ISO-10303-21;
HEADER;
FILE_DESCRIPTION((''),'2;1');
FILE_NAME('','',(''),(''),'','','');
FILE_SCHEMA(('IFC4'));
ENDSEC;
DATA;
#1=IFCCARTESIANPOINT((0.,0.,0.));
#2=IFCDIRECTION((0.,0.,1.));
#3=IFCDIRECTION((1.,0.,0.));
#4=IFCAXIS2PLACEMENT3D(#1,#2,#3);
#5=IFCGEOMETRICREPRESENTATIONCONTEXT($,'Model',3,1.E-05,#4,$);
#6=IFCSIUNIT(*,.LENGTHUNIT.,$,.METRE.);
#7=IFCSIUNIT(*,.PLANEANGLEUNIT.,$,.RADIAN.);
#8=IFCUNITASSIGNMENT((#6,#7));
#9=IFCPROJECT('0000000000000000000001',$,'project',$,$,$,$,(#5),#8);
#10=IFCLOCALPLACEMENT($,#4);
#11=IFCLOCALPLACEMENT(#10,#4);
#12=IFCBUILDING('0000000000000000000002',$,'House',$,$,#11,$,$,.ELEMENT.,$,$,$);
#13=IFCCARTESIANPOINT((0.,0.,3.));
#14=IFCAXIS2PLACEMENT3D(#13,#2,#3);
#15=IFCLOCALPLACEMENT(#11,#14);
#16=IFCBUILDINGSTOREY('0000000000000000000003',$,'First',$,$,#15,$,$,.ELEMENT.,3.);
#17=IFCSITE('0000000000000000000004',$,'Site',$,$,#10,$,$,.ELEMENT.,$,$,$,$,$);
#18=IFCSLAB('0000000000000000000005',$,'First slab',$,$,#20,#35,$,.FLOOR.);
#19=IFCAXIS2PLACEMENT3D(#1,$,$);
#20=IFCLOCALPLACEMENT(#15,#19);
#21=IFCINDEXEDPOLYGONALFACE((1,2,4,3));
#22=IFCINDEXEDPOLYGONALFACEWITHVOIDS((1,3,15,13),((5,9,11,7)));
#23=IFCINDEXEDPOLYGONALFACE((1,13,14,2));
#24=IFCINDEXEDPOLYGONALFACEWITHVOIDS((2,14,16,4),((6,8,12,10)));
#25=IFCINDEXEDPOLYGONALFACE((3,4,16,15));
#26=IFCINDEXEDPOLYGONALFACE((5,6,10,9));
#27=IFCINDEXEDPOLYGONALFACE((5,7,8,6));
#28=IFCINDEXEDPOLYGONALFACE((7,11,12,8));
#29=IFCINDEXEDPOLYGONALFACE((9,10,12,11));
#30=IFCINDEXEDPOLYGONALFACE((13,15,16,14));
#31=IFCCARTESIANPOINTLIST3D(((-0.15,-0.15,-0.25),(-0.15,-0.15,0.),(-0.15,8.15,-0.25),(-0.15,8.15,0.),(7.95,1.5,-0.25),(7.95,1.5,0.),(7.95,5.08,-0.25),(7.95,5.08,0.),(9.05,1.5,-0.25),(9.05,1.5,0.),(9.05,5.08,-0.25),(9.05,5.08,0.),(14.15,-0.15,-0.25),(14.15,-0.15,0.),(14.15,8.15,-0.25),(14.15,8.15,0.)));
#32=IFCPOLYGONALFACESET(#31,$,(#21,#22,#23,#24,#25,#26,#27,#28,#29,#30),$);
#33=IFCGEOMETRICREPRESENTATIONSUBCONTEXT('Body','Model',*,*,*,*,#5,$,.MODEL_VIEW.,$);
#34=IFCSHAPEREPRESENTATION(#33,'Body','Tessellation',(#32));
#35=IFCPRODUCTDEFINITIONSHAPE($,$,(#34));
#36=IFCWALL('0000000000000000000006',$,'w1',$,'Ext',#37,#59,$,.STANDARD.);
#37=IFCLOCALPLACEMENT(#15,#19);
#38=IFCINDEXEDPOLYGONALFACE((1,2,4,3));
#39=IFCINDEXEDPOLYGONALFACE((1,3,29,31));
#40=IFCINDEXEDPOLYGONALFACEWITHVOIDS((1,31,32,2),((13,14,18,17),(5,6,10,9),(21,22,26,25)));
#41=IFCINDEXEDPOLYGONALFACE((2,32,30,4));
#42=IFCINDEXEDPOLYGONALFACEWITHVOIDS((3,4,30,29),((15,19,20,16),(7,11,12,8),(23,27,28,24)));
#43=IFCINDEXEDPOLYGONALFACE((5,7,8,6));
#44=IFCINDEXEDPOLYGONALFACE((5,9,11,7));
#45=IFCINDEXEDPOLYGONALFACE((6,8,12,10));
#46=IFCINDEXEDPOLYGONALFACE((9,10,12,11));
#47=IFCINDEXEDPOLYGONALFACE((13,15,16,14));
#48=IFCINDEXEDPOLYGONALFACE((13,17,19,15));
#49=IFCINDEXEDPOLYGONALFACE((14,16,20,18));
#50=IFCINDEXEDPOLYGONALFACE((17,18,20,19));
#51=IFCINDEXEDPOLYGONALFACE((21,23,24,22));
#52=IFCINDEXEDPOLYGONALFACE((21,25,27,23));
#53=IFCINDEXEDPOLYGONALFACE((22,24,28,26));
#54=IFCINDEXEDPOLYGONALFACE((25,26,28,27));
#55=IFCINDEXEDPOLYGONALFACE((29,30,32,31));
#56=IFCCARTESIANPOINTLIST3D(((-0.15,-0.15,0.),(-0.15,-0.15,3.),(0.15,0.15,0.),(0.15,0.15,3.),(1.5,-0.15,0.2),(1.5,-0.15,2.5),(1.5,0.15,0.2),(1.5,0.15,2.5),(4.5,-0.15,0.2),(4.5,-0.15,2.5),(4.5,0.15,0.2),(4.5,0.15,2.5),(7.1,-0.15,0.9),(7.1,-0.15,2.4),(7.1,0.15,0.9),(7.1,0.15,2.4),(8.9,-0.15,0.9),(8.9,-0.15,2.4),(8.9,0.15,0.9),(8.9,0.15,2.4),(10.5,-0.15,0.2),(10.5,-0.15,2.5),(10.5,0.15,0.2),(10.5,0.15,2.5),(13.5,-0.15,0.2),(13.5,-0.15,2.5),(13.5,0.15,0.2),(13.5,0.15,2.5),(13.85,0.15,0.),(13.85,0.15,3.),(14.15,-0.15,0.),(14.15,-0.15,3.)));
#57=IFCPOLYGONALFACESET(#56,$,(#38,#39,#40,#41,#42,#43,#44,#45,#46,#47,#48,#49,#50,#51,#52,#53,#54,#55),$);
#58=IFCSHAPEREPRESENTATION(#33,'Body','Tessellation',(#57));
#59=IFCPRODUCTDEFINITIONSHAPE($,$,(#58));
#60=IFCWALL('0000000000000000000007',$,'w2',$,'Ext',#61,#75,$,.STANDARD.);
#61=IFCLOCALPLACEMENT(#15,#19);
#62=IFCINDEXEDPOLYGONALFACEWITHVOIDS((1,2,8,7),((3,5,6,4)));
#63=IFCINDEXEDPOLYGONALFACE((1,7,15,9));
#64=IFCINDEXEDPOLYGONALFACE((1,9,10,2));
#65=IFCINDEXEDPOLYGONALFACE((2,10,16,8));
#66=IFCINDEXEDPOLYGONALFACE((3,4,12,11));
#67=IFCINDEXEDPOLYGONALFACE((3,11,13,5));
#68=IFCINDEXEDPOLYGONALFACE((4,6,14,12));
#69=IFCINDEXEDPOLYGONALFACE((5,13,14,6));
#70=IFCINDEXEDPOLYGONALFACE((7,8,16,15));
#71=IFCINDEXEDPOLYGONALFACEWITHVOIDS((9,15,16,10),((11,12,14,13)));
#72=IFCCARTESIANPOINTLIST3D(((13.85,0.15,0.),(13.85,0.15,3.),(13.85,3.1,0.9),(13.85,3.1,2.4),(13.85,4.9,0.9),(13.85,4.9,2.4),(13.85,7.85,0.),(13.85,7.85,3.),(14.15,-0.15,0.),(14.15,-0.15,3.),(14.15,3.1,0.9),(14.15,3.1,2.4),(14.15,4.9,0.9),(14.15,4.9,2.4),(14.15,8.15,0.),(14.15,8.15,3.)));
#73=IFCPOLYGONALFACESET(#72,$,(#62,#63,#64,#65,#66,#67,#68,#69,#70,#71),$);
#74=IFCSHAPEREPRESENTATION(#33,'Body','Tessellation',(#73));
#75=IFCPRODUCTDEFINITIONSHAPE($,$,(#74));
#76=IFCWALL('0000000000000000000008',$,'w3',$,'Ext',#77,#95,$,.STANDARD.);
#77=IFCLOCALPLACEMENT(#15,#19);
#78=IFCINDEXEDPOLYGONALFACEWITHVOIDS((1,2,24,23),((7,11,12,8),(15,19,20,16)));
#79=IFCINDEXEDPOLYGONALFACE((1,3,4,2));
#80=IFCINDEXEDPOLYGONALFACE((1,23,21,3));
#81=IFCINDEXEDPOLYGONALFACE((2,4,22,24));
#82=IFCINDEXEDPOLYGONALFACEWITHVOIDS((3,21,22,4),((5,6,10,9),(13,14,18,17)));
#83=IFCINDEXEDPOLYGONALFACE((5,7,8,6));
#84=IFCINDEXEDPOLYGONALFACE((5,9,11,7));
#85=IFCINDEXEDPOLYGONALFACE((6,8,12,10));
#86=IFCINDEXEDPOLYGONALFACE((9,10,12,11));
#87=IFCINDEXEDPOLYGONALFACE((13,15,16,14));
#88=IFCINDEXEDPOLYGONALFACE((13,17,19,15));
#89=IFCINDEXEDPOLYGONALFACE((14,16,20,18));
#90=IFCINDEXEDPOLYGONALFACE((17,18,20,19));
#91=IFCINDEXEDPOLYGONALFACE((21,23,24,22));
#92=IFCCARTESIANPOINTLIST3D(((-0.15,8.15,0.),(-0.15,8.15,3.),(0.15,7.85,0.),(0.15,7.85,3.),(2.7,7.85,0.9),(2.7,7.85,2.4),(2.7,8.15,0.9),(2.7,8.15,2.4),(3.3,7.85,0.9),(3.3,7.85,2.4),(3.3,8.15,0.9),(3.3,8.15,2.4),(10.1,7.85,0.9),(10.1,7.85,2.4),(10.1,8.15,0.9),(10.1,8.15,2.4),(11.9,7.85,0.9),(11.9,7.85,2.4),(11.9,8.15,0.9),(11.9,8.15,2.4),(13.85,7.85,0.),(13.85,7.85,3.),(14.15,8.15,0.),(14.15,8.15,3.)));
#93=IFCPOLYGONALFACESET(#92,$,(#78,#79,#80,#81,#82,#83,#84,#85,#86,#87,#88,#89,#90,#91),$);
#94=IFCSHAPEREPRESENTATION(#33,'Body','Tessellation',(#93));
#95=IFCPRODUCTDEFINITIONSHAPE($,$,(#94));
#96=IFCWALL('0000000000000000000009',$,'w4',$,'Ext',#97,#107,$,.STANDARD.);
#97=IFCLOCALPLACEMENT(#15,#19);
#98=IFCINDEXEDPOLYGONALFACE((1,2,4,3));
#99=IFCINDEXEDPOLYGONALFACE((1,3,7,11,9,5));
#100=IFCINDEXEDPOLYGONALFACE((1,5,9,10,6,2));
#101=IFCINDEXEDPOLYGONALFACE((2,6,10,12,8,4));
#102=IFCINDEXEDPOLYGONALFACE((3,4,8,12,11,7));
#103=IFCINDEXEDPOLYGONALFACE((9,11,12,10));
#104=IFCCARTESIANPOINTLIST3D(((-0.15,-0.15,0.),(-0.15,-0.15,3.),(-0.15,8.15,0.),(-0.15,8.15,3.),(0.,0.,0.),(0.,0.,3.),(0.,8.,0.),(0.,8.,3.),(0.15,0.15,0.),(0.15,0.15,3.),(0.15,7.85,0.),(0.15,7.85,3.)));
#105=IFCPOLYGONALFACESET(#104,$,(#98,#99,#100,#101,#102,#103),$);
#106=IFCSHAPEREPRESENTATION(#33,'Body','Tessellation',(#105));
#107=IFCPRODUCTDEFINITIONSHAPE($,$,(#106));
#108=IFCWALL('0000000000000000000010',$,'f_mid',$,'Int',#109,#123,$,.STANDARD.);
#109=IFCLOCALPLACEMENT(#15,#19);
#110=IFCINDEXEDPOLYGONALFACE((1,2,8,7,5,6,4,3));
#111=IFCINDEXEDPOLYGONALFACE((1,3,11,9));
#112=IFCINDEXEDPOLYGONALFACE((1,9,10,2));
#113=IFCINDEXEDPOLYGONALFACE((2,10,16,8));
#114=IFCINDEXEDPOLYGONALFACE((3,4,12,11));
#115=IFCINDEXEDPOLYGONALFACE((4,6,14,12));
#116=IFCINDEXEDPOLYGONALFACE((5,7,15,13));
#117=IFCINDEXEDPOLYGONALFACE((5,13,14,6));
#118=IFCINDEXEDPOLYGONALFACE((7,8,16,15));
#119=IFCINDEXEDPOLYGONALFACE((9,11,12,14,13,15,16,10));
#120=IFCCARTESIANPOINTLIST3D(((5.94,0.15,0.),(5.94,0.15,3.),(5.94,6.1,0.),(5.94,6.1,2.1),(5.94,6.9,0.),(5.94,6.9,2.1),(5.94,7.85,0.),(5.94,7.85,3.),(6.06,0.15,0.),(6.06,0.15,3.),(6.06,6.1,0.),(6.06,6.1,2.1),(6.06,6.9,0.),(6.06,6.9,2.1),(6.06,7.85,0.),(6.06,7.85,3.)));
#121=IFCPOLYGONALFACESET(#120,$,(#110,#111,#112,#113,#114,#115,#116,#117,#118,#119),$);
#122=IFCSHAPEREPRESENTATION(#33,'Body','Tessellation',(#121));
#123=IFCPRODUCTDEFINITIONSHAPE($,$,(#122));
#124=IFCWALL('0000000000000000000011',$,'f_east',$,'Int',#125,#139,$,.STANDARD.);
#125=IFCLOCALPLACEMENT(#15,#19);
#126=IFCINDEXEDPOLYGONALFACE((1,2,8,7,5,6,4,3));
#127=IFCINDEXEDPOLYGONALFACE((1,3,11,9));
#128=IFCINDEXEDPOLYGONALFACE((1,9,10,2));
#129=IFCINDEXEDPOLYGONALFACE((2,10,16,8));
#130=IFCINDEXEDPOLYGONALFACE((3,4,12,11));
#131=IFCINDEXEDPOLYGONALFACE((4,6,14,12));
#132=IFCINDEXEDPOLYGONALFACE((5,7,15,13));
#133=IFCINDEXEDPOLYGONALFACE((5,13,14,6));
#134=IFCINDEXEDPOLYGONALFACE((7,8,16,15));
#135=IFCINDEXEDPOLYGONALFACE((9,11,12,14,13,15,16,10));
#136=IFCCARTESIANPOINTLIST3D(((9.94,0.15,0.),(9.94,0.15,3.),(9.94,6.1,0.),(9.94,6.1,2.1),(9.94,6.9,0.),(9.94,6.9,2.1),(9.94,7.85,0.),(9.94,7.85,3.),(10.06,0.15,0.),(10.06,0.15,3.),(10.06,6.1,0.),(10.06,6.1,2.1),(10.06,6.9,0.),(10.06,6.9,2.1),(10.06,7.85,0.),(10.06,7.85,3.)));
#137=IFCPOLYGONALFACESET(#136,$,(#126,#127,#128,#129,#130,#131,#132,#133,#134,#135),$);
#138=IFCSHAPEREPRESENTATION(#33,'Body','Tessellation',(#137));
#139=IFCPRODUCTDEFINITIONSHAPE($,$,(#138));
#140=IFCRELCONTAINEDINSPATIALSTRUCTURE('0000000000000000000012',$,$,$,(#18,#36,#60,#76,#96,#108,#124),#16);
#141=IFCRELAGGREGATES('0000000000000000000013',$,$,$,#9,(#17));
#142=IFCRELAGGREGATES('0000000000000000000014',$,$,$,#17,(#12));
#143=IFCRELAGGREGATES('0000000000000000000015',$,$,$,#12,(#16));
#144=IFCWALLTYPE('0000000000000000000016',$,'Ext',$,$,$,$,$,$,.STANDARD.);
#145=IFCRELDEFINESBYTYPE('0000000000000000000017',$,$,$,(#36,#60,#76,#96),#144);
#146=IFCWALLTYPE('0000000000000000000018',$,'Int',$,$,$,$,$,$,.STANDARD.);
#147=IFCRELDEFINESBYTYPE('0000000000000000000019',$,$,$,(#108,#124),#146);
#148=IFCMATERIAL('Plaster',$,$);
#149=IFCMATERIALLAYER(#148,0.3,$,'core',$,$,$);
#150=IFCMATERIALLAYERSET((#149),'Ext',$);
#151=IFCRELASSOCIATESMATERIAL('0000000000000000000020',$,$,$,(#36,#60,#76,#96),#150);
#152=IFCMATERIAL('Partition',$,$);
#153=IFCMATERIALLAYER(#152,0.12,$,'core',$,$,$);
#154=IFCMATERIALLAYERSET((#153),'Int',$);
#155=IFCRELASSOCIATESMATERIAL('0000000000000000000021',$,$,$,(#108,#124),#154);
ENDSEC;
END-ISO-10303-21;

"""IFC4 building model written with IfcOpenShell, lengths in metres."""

from ifc_helpers import new_model, si_unit, frame, origin_with_axes, origin_2d_with_axis, place, context, subcontext, project, spatial, polyline, rectangle, outline, extrude, material, layer, layer_set, layer_usage, type_object, element, save


model = new_model("IFC4")

# Units and contexts
model_context = context("Model", 3, precision=1e-05, world=origin_with_axes())
body_context = subcontext(model_context, "Body", "Model", "MODEL_VIEW")
ifc_project = project(units=[si_unit("LENGTHUNIT", "METRE"), si_unit("PLANEANGLEUNIT", "RADIAN")], contexts=[model_context])

# Site, building, storey
site_placement = place(None, origin_with_axes())
site = spatial("IfcSite", under=ifc_project, at=site_placement, Name="Site", CompositionType="ELEMENT")
building_placement = place(site_placement, origin_with_axes())
building = spatial("IfcBuilding", under=site, at=building_placement, Name="House", CompositionType="ELEMENT")
storey_placement = place(building_placement, frame((0.0, 0.0, 3.0), z_axis=(0.0, 0.0, 1.0), x_axis=(1.0, 0.0, 0.0)))
storey = spatial("IfcBuildingStorey", under=building, at=storey_placement, Name="First", CompositionType="ELEMENT", Elevation=3.0)

# Slab
slab_placement = place(storey_placement, frame((0.0, 0.0, -0.25), z_axis=(0.0, 0.0, 1.0), x_axis=(1.0, 0.0, 0.0)))
element("IfcSlab", 1, at=slab_placement, inside=storey, Name="First slab", PredefinedType="FLOOR", context=body_context, shape_type="SweptSolid", body=[
    extrude(outline(polyline([(14.15, -0.15), (14.15, 8.15), (-0.15, 8.15), (-0.15, -0.15), (14.15, -0.15)]), holes=[polyline([(7.95, 1.5), (7.95, 5.08), (9.05, 5.08), (9.05, 1.5), (7.95, 1.5)])]), origin_with_axes(), (0.0, 0.0, 1.0), 0.25),
])

# Wall, openings
ifc_material_1 = material(Name="Plaster")
ifc_layer_1 = layer(ifc_material_1, 0.3, Name="core")
ifc_layer_set_1 = layer_set([ifc_layer_1], Name="Ext")
ifc_layer_usage_1 = layer_usage(ifc_layer_set_1, "AXIS2", "POSITIVE", -0.15)
wall_type_1 = type_object("IfcWallType", Name="Ext", PredefinedType="STANDARD")
wall_1_placement = place(storey_placement, origin_with_axes())
wall_1 = element("IfcWall", 2, at=wall_1_placement, inside=storey, type_object=wall_type_1, material=ifc_layer_usage_1, Name="w1", ObjectType="Ext", PredefinedType="STANDARD", context=body_context, shape_type="SweptSolid", body=[
    extrude(outline(polyline([(-0.15, -0.15), (14.15, -0.15), (14.0, 0.0), (13.85, 0.15), (0.15, 0.15), (0.0, 0.0), (-0.15, -0.15)])), origin_with_axes(), (0.0, 0.0, 1.0), 3.0),
])
opening_1_placement = place(wall_1_placement, frame((3.0, -0.16, 1.35), z_axis=(0.0, 1.0, 0.0), x_axis=(1.0, 0.0, 0.0)))
element("IfcOpeningElement", 3, at=opening_1_placement, cuts=wall_1, PredefinedType="OPENING", context=body_context, shape_type="SweptSolid", body=[
    extrude(rectangle(XDim=3.0, YDim=2.3, at=origin_2d_with_axis()), origin_with_axes(), (0.0, 0.0, 1.0), 0.32),
])
opening_2_placement = place(wall_1_placement, frame((8.0, -0.16, 1.65), z_axis=(0.0, 1.0, 0.0), x_axis=(1.0, 0.0, 0.0)))
element("IfcOpeningElement", 4, at=opening_2_placement, cuts=wall_1, PredefinedType="OPENING", context=body_context, shape_type="SweptSolid", body=[
    extrude(rectangle(XDim=1.8, YDim=1.5, at=origin_2d_with_axis()), origin_with_axes(), (0.0, 0.0, 1.0), 0.32),
])
opening_3_placement = place(wall_1_placement, frame((12.0, -0.16, 1.35), z_axis=(0.0, 1.0, 0.0), x_axis=(1.0, 0.0, 0.0)))
element("IfcOpeningElement", 5, at=opening_3_placement, cuts=wall_1, PredefinedType="OPENING", context=body_context, shape_type="SweptSolid", body=[
    extrude(rectangle(XDim=3.0, YDim=2.3, at=origin_2d_with_axis()), origin_with_axes(), (0.0, 0.0, 1.0), 0.32),
])

# Wall, opening
ifc_layer_usage_2 = layer_usage(ifc_layer_set_1, "AXIS2", "POSITIVE", -0.15)
wall_2_placement = place(storey_placement, frame((14.0, 0.0, 0.0), z_axis=(0.0, 0.0, 1.0), x_axis=(0.0, 1.0, 0.0)))
wall_2 = element("IfcWall", 6, at=wall_2_placement, inside=storey, type_object=wall_type_1, material=ifc_layer_usage_2, Name="w2", ObjectType="Ext", PredefinedType="STANDARD", context=body_context, shape_type="SweptSolid", body=[
    extrude(outline(polyline([(-0.15, -0.15), (8.15, -0.15), (8.0, 0.0), (7.85, 0.15), (0.15, 0.15), (0.0, 0.0), (-0.15, -0.15)])), origin_with_axes(), (0.0, 0.0, 1.0), 3.0),
])
opening_4_placement = place(wall_2_placement, frame((4.0, -0.16, 1.65), z_axis=(0.0, 1.0, 0.0), x_axis=(1.0, 0.0, 0.0)))
element("IfcOpeningElement", 7, at=opening_4_placement, cuts=wall_2, PredefinedType="OPENING", context=body_context, shape_type="SweptSolid", body=[
    extrude(rectangle(XDim=1.8, YDim=1.5, at=origin_2d_with_axis()), origin_with_axes(), (0.0, 0.0, 1.0), 0.32),
])

# Wall, openings
ifc_layer_usage_3 = layer_usage(ifc_layer_set_1, "AXIS2", "POSITIVE", -0.15)
wall_3_placement = place(storey_placement, frame((14.0, 8.0, 0.0), z_axis=(0.0, 0.0, 1.0), x_axis=(-1.0, 0.0, 0.0)))
wall_3 = element("IfcWall", 8, at=wall_3_placement, inside=storey, type_object=wall_type_1, material=ifc_layer_usage_3, Name="w3", ObjectType="Ext", PredefinedType="STANDARD", context=body_context, shape_type="SweptSolid", body=[
    extrude(outline(polyline([(-0.15, -0.15), (14.15, -0.15), (14.0, 0.0), (13.85, 0.15), (0.15, 0.15), (0.0, 0.0), (-0.15, -0.15)])), origin_with_axes(), (0.0, 0.0, 1.0), 3.0),
])
opening_5_placement = place(wall_3_placement, frame((11.0, -0.16, 1.65), z_axis=(0.0, 1.0, 0.0), x_axis=(1.0, 0.0, 0.0)))
element("IfcOpeningElement", 9, at=opening_5_placement, cuts=wall_3, PredefinedType="OPENING", context=body_context, shape_type="SweptSolid", body=[
    extrude(rectangle(XDim=0.6, YDim=1.5, at=origin_2d_with_axis()), origin_with_axes(), (0.0, 0.0, 1.0), 0.32),
])
opening_6_placement = place(wall_3_placement, frame((3.0, -0.16, 1.65), z_axis=(0.0, 1.0, 0.0), x_axis=(1.0, 0.0, 0.0)))
element("IfcOpeningElement", 10, at=opening_6_placement, cuts=wall_3, PredefinedType="OPENING", context=body_context, shape_type="SweptSolid", body=[
    extrude(rectangle(XDim=1.8, YDim=1.5, at=origin_2d_with_axis()), origin_with_axes(), (0.0, 0.0, 1.0), 0.32),
])

# Wall
ifc_layer_usage_4 = layer_usage(ifc_layer_set_1, "AXIS2", "POSITIVE", -0.15)
wall_4_placement = place(storey_placement, frame((0.0, 8.0, 0.0), z_axis=(0.0, 0.0, 1.0), x_axis=(0.0, -1.0, 0.0)))
element("IfcWall", 11, at=wall_4_placement, inside=storey, type_object=wall_type_1, material=ifc_layer_usage_4, Name="w4", ObjectType="Ext", PredefinedType="STANDARD", context=body_context, shape_type="SweptSolid", body=[
    extrude(outline(polyline([(-0.15, -0.15), (8.15, -0.15), (8.0, 0.0), (7.85, 0.15), (0.15, 0.15), (0.0, 0.0), (-0.15, -0.15)])), origin_with_axes(), (0.0, 0.0, 1.0), 3.0),
])

# Walls, openings
ifc_material_2 = material(Name="Partition")
ifc_layer_2 = layer(ifc_material_2, 0.12, Name="core")
ifc_layer_set_2 = layer_set([ifc_layer_2], Name="Int")
ifc_layer_usage_5 = layer_usage(ifc_layer_set_2, "AXIS2", "POSITIVE", -0.06)
wall_type_2 = type_object("IfcWallType", Name="Int", PredefinedType="STANDARD")
wall_5_placement = place(storey_placement, frame((6.0, 0.0, 0.0), z_axis=(0.0, 0.0, 1.0), x_axis=(0.0, 1.0, 0.0)))
wall_5 = element("IfcWall", 12, at=wall_5_placement, inside=storey, type_object=wall_type_2, material=ifc_layer_usage_5, Name="f_mid", ObjectType="Int", PredefinedType="STANDARD", context=body_context, shape_type="SweptSolid", body=[
    extrude(outline(polyline([(0.15, -0.06), (7.85, -0.06), (7.85, 0.06), (0.15, 0.06), (0.15, -0.06)])), origin_with_axes(), (0.0, 0.0, 1.0), 3.0),
])
opening_7_placement = place(wall_5_placement, frame((6.5, -0.07, 1.05), z_axis=(0.0, 1.0, 0.0), x_axis=(1.0, 0.0, 0.0)))
element("IfcOpeningElement", 13, at=opening_7_placement, cuts=wall_5, PredefinedType="OPENING", context=body_context, shape_type="SweptSolid", body=[
    extrude(rectangle(XDim=0.8, YDim=2.1, at=origin_2d_with_axis()), origin_with_axes(), (0.0, 0.0, 1.0), 0.14),
])
ifc_layer_usage_6 = layer_usage(ifc_layer_set_2, "AXIS2", "POSITIVE", -0.06)
wall_6_placement = place(storey_placement, frame((10.0, 0.0, 0.0), z_axis=(0.0, 0.0, 1.0), x_axis=(0.0, 1.0, 0.0)))
wall_6 = element("IfcWall", 14, at=wall_6_placement, inside=storey, type_object=wall_type_2, material=ifc_layer_usage_6, Name="f_east", ObjectType="Int", PredefinedType="STANDARD", context=body_context, shape_type="SweptSolid", body=[
    extrude(outline(polyline([(0.15, -0.06), (7.85, -0.06), (7.85, 0.06), (0.15, 0.06), (0.15, -0.06)])), origin_with_axes(), (0.0, 0.0, 1.0), 3.0),
])
opening_8_placement = place(wall_6_placement, frame((6.5, -0.07, 1.05), z_axis=(0.0, 1.0, 0.0), x_axis=(1.0, 0.0, 0.0)))
element("IfcOpeningElement", 15, at=opening_8_placement, cuts=wall_6, PredefinedType="OPENING", context=body_context, shape_type="SweptSolid", body=[
    extrude(rectangle(XDim=0.8, YDim=2.1, at=origin_2d_with_axis()), origin_with_axes(), (0.0, 0.0, 1.0), 0.14),
])

save(model, "model.ifc")
